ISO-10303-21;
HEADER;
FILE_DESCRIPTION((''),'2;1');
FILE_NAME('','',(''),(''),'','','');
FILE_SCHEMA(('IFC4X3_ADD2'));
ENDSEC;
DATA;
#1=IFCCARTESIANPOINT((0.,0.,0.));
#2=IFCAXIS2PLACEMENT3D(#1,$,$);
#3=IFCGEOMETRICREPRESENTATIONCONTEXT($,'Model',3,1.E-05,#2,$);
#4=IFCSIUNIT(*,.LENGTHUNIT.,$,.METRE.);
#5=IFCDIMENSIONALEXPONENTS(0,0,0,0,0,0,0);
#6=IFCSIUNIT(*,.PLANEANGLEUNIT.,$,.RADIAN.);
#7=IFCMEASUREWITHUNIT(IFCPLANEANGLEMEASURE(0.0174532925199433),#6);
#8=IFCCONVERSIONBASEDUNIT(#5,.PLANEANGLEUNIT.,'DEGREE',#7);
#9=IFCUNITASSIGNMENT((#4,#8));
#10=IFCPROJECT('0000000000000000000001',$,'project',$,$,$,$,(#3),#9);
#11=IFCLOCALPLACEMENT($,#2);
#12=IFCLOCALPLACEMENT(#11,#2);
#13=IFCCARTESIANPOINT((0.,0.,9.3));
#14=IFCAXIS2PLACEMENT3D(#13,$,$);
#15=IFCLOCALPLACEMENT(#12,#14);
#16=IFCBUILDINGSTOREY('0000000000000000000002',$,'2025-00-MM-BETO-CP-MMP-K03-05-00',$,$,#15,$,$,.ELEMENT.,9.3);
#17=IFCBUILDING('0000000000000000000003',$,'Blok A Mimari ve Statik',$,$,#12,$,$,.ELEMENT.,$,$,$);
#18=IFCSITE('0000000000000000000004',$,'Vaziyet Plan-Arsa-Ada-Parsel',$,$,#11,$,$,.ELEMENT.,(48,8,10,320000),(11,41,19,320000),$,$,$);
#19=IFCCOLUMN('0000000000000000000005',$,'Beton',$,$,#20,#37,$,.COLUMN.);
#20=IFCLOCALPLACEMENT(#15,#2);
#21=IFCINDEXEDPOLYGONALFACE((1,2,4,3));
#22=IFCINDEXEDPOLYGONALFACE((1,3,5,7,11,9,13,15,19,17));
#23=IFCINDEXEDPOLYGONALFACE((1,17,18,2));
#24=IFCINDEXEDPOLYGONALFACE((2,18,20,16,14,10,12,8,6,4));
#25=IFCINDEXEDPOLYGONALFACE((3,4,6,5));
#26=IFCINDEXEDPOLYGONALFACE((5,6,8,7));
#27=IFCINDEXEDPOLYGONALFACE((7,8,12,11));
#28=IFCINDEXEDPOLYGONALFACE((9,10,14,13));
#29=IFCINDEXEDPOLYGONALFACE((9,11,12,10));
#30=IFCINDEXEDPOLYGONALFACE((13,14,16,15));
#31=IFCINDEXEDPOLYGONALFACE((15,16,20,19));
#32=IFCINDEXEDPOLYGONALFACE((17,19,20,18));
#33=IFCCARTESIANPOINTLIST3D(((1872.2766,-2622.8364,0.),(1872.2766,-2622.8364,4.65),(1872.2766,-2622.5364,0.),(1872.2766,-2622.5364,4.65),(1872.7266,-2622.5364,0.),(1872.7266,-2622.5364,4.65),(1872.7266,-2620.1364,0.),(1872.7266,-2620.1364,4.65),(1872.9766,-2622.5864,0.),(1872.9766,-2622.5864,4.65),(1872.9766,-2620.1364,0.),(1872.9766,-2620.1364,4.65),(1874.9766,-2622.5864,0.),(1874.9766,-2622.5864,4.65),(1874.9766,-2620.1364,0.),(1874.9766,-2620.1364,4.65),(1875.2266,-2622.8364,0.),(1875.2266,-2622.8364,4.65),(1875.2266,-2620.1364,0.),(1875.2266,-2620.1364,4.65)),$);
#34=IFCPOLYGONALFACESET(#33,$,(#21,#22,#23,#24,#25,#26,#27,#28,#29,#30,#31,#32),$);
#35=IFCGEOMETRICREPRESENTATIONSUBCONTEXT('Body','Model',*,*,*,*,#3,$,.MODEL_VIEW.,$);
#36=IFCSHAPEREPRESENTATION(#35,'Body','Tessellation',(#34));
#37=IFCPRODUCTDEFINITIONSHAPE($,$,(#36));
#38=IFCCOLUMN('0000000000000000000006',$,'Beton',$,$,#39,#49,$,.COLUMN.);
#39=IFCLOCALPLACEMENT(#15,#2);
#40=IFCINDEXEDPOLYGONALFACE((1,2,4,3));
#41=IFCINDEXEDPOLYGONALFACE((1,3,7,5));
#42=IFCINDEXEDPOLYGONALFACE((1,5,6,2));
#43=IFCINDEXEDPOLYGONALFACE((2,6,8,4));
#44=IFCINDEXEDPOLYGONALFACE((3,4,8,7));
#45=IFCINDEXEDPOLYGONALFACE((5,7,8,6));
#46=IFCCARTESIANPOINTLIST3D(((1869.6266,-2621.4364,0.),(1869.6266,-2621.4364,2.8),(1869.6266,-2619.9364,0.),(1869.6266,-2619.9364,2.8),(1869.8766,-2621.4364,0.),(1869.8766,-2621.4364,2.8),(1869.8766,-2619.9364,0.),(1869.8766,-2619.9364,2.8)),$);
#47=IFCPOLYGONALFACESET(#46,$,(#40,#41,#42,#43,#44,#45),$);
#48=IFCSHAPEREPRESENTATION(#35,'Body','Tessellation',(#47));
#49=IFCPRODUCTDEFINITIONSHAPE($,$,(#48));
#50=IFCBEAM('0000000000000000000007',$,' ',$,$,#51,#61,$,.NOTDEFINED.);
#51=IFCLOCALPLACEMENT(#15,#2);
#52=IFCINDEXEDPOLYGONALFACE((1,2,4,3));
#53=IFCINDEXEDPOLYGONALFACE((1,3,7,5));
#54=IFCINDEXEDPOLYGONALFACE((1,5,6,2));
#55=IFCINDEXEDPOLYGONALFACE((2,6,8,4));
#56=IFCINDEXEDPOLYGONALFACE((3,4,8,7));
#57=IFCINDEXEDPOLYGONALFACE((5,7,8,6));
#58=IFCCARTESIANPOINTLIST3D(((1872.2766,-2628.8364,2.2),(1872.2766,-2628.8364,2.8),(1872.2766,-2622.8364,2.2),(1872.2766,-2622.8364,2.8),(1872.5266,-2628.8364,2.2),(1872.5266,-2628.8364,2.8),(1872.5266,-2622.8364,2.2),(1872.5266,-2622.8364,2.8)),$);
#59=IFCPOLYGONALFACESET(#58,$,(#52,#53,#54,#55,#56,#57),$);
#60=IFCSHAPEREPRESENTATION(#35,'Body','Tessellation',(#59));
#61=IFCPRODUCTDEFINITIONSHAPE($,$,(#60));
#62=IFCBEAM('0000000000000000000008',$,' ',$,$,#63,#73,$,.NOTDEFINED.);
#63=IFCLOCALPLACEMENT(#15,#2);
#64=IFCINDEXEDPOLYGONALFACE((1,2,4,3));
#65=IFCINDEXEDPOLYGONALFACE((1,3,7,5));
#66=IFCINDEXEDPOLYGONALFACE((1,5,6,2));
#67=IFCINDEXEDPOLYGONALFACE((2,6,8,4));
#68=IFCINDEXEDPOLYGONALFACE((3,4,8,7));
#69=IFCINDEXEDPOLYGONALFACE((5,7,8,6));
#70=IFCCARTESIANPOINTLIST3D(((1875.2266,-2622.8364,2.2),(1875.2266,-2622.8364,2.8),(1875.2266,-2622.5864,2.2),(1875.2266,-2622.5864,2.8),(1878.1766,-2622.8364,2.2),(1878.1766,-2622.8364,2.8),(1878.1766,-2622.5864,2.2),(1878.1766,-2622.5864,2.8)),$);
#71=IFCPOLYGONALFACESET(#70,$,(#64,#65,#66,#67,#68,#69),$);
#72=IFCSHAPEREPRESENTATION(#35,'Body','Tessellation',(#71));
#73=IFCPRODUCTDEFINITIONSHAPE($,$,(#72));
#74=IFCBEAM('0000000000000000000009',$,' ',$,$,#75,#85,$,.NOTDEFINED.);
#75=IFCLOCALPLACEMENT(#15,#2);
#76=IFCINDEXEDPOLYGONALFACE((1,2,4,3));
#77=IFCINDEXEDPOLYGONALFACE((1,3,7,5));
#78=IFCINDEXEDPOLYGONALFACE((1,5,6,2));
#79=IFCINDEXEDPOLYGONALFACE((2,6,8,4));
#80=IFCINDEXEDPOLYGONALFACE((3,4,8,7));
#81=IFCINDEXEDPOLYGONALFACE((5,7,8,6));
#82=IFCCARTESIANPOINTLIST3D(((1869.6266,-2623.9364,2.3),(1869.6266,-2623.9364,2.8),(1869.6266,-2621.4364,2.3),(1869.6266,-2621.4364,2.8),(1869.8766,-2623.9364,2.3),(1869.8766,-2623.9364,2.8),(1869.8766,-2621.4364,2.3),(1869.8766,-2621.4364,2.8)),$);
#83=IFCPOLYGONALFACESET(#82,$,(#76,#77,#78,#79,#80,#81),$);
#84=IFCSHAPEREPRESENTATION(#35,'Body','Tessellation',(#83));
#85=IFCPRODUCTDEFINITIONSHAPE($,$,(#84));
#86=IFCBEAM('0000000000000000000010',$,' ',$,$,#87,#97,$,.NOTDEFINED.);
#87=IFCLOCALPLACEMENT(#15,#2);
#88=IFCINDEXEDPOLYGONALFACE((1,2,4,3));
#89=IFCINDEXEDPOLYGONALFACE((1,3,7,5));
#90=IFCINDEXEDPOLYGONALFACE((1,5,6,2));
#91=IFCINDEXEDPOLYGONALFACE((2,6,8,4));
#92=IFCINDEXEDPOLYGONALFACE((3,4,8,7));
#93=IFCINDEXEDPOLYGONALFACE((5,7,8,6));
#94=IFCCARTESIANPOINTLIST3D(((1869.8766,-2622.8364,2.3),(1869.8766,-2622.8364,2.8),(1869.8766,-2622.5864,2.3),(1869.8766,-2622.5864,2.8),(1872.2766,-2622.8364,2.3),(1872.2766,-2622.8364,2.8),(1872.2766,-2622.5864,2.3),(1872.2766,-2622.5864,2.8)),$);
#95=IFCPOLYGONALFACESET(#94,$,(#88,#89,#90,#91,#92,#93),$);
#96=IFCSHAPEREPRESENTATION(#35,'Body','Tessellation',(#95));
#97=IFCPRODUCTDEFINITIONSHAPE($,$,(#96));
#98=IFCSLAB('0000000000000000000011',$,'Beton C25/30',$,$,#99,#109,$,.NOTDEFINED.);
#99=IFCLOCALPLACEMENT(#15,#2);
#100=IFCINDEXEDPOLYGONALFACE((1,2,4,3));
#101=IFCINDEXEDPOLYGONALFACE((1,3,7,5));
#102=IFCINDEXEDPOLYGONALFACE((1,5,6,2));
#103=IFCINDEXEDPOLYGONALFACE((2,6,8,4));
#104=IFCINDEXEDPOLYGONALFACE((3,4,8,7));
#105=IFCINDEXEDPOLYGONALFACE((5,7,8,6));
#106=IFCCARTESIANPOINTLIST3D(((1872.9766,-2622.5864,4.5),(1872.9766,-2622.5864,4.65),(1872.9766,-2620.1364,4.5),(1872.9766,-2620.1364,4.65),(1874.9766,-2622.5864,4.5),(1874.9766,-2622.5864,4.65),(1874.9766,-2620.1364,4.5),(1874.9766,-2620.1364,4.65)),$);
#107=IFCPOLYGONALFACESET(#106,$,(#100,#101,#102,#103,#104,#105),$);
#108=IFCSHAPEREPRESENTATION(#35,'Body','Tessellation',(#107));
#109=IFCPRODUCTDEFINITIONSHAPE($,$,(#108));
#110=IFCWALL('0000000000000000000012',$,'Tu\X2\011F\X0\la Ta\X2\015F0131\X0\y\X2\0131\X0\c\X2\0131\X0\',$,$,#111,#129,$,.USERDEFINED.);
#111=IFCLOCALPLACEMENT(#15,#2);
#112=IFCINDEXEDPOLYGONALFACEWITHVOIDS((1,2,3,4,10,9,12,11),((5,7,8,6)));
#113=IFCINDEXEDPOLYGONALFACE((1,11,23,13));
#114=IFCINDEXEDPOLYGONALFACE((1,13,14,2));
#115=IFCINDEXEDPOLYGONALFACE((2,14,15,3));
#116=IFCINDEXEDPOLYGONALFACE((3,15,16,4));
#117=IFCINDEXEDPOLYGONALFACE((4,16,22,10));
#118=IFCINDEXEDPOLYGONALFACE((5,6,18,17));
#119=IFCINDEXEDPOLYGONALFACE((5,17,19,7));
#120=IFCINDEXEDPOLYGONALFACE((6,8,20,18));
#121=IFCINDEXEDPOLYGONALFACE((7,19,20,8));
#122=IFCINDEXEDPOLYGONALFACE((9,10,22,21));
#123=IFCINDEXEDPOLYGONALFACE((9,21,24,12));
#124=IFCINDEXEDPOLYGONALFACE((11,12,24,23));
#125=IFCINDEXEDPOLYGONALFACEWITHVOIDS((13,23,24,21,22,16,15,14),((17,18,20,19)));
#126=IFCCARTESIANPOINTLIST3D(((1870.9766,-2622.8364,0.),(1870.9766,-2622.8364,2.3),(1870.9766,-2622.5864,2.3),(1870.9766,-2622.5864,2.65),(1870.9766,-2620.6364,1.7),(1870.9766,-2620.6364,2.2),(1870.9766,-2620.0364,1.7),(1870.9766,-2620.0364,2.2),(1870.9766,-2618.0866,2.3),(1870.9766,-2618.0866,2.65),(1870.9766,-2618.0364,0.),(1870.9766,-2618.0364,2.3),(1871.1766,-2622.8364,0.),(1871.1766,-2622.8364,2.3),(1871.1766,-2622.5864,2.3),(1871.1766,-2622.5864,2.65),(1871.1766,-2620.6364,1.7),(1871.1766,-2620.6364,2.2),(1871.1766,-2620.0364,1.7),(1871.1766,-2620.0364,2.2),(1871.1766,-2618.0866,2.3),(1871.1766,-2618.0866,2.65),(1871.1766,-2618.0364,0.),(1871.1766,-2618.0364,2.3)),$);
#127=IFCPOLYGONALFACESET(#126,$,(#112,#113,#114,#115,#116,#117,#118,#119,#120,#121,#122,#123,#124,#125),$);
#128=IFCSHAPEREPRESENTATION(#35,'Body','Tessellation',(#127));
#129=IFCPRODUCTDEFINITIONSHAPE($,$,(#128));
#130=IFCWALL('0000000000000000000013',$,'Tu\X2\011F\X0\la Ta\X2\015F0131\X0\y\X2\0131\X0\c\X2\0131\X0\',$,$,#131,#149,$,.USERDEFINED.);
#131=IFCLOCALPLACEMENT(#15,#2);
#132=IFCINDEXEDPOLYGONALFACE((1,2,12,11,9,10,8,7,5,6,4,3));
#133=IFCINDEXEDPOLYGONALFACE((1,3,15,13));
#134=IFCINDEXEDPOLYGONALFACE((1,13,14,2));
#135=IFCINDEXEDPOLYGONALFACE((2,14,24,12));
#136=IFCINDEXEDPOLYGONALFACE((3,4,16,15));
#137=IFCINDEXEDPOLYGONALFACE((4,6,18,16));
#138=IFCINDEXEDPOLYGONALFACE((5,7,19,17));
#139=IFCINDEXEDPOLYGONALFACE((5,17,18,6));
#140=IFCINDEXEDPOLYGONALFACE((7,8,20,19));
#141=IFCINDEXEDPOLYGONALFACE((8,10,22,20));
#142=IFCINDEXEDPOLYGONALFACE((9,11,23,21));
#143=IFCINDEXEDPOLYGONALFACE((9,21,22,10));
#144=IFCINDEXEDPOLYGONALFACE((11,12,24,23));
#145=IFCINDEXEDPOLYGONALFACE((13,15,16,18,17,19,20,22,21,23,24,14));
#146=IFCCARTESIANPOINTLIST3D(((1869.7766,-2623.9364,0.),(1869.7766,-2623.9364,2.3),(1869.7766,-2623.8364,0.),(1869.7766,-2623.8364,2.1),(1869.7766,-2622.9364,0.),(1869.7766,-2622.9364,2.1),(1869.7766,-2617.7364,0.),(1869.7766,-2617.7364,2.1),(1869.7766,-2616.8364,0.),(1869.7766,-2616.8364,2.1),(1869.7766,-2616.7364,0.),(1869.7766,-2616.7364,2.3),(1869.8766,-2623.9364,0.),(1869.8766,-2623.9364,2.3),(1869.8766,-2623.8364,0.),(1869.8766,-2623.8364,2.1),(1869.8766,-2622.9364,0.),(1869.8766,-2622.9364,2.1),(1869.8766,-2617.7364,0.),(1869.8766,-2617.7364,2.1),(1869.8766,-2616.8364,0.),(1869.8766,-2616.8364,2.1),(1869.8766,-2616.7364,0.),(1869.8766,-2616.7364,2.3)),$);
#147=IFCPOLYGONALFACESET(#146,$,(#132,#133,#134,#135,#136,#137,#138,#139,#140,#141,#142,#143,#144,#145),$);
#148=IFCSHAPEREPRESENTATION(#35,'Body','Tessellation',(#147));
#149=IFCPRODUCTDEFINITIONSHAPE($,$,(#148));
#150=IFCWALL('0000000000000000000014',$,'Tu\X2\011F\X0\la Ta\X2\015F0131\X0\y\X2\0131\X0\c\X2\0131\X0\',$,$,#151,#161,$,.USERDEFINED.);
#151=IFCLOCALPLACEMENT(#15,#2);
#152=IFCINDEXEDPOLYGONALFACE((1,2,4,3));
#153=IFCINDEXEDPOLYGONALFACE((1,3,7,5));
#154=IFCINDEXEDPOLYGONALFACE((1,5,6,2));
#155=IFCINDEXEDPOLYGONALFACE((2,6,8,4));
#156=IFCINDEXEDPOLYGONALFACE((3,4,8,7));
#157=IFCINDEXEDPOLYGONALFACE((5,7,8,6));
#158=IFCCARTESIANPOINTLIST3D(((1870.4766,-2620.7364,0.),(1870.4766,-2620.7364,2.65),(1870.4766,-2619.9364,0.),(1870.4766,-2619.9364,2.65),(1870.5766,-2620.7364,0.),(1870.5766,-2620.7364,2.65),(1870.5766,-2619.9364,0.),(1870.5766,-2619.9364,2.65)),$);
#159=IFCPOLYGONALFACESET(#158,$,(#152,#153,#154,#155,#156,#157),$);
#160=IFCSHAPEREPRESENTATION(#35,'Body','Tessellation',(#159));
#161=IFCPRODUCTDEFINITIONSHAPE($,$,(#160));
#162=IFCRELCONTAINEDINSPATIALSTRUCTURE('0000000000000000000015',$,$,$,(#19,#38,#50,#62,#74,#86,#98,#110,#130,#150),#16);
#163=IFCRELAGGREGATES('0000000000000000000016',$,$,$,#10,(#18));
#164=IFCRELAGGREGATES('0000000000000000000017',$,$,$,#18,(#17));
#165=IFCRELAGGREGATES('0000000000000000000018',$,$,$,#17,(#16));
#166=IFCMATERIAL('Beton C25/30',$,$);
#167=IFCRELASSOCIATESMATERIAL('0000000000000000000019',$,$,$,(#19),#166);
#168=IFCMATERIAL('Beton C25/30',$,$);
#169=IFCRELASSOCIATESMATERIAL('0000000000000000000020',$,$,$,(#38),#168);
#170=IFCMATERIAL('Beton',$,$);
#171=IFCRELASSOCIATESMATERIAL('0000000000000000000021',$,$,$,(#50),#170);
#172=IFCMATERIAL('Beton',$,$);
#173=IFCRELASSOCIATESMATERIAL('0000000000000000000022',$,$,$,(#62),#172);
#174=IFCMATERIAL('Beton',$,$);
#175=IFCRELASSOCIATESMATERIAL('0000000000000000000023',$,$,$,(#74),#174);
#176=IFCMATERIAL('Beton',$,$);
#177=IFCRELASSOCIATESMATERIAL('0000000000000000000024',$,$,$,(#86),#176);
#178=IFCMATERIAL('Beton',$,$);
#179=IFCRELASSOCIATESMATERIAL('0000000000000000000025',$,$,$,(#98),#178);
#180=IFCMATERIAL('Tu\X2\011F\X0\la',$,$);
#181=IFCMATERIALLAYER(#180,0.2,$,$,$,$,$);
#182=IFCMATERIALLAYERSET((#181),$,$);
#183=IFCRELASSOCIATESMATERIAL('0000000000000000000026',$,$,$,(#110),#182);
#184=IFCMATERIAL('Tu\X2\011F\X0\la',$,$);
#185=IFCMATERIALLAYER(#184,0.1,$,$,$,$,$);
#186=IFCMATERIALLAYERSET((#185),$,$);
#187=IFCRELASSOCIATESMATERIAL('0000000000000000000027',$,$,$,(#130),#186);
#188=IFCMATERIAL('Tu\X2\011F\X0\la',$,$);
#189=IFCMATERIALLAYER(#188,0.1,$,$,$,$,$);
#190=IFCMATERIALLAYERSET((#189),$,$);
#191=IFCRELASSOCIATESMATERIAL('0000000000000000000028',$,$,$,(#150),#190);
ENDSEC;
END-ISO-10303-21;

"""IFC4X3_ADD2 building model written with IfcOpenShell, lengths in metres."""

from ifc_helpers import new_model, entity, si_unit, converted_unit, frame, frame_2d, origin, origin_with_axes, place, context, subcontext, project, spatial, polyline, rectangle, outline, extrude, clip, bounded_halfspace, material, layer, layer_set, layer_usage, element, save


model = new_model("IFC4X3_ADD2")

# Units and contexts
model_context = context("Model", 3, precision=1e-05, world=origin())
body_context = subcontext(model_context, "Body", "Model", "MODEL_VIEW")
ifc_project = project(units=[si_unit("LENGTHUNIT", "METRE"), converted_unit("PLANEANGLEUNIT", "DEGREE", entity("IfcPlaneAngleMeasure", 0.0174532925199433), si_unit("PLANEANGLEUNIT", "RADIAN"), dimensions=[0, 0, 0, 0, 0, 0, 0])], contexts=[model_context])

# Site, building, storey
site_placement = place(None, origin())
site = spatial("IfcSite", under=ifc_project, at=site_placement, Name="Vaziyet Plan-Arsa-Ada-Parsel", CompositionType="ELEMENT", RefLatitude=(48, 8, 10, 320000), RefLongitude=(11, 41, 19, 320000))
building_placement = place(site_placement, origin())
building = spatial("IfcBuilding", under=site, at=building_placement, Name="Blok A Mimari ve Statik", CompositionType="ELEMENT")
storey_placement = place(building_placement, frame((0.0, 0.0, 9.3)))
storey = spatial("IfcBuildingStorey", under=building, at=storey_placement, Name="2025-00-MM-BETO-CP-MMP-K03-05-00", CompositionType="ELEMENT", Elevation=9.3)

# Columns
ifc_material_1 = material(Name="Beton C25/30")
column_1_placement = place(storey_placement, frame((1872.2766, -2622.8364, 0.0)))
element("IfcColumn", 1, at=column_1_placement, inside=storey, material=ifc_material_1, Name="Beton", PredefinedType="COLUMN", context=body_context, shape_type="SweptSolid", body=[
    extrude(outline(polyline([(0.45, 0.3), (0.0, 0.3), (0.0, 0.0), (2.95, 0.0), (2.95, 2.7), (2.7, 2.7), (2.7, 0.25), (0.7, 0.25), (0.7, 2.7), (0.45, 2.7), (0.45, 0.3)])), origin_with_axes(), (0.0, 0.0, 1.0), 4.65),
])
ifc_material_2 = material(Name="Beton C25/30")
column_2_placement = place(storey_placement, frame((1869.6266, -2621.4364, 0.0)))
element("IfcColumn", 2, at=column_2_placement, inside=storey, material=ifc_material_2, Name="Beton", PredefinedType="COLUMN", context=body_context, shape_type="SweptSolid", body=[
    extrude(outline(polyline([(0.0, 0.0), (0.25, 0.0), (0.25, 1.5), (0.0, 1.5), (0.0, 0.0)])), origin_with_axes(), (0.0, 0.0, 1.0), 2.8),
])

# Beams
ifc_material_3 = material(Name="Beton")
beam_1_placement = place(storey_placement, frame((1872.2766, -2622.8364, 2.2), z_axis=(0.0, 0.0, 1.0), x_axis=(0.0, -1.0, 0.0)))
element("IfcBeam", 3, at=beam_1_placement, inside=storey, material=ifc_material_3, Name=" ", PredefinedType="NOTDEFINED", context=body_context, shape_type="SweptSolid", body=[
    extrude(rectangle(XDim=0.25, YDim=0.6, at=frame_2d((0.125, 0.3), x_axis=(1.0, 0.0))), frame((0.0, 0.0, 0.0), z_axis=(1.0, 0.0, 0.0), x_axis=(0.0, 1.0, 0.0)), (0.0, 0.0, 1.0), 6.0),
])
ifc_material_4 = material(Name="Beton")
beam_2_placement = place(storey_placement, frame((1875.2266, -2622.8364, 2.2)))
element("IfcBeam", 4, at=beam_2_placement, inside=storey, material=ifc_material_4, Name=" ", PredefinedType="NOTDEFINED", context=body_context, shape_type="SweptSolid", body=[
    extrude(rectangle(XDim=0.25, YDim=0.6, at=frame_2d((0.125, 0.3), x_axis=(1.0, 0.0))), frame((0.0, 0.0, 0.0), z_axis=(1.0, 0.0, 0.0), x_axis=(0.0, 1.0, 0.0)), (0.0, 0.0, 1.0), 2.95),
])
ifc_material_5 = material(Name="Beton")
beam_3_placement = place(storey_placement, frame((1869.8766, -2623.9364, 2.3), z_axis=(0.0, 0.0, 1.0), x_axis=(0.0, 1.0, 0.0)))
element("IfcBeam", 5, at=beam_3_placement, inside=storey, material=ifc_material_5, Name=" ", PredefinedType="NOTDEFINED", context=body_context, shape_type="SweptSolid", body=[
    extrude(rectangle(XDim=0.25, YDim=0.5, at=frame_2d((0.125, 0.25), x_axis=(1.0, 0.0))), frame((0.0, 0.0, 0.0), z_axis=(1.0, 0.0, 0.0), x_axis=(0.0, 1.0, 0.0)), (0.0, 0.0, 1.0), 2.5),
])
ifc_material_6 = material(Name="Beton")
beam_4_placement = place(storey_placement, frame((1869.8766, -2622.8364, 2.3), z_axis=(0.0, 0.0, 1.0), x_axis=(1.0, 0.0, 0.0)))
element("IfcBeam", 6, at=beam_4_placement, inside=storey, material=ifc_material_6, Name=" ", PredefinedType="NOTDEFINED", context=body_context, shape_type="SweptSolid", body=[
    extrude(rectangle(XDim=0.25, YDim=0.5, at=frame_2d((0.125, 0.25), x_axis=(1.0, 0.0))), frame((0.0, 0.0, 0.0), z_axis=(1.0, 0.0, 0.0), x_axis=(0.0, 1.0, 0.0)), (0.0, 0.0, 1.0), 2.4),
])

# Slab
ifc_material_7 = material(Name="Beton")
slab_1_placement = place(storey_placement, frame((1872.9766, -2622.5864, 4.5)))
element("IfcSlab", 7, at=slab_1_placement, inside=storey, material=ifc_material_7, Name="Beton C25/30", PredefinedType="NOTDEFINED", context=body_context, shape_type="SweptSolid", body=[
    extrude(rectangle(XDim=2.0, YDim=2.45, at=frame_2d((1.0, 1.225), x_axis=(1.0, 0.0))), origin_with_axes(), (0.0, 0.0, 1.0), 0.15),
])

# Wall, opening
ifc_material_8 = material(Name="Tuğla")
ifc_layer_1 = layer(ifc_material_8, 0.2)
ifc_layer_set_1 = layer_set([ifc_layer_1])
ifc_layer_usage_1 = layer_usage(ifc_layer_set_1, "AXIS2", "POSITIVE", 0.0)
wall_1_placement = place(storey_placement, frame((1871.1766, -2622.8364, 0.0), z_axis=(0.0, 0.0, 1.0), x_axis=(0.0, 1.0, 0.0)))
wall_1 = element("IfcWall", 8, at=wall_1_placement, inside=storey, material=ifc_layer_usage_1, Name="Tuğla Taşıyıcı", PredefinedType="USERDEFINED", context=body_context, shape_type="Clipping", body=[
    clip(clip(extrude(rectangle(XDim=4.8, YDim=0.2, at=frame_2d((2.4, 0.1), x_axis=(1.0, 0.0))), origin_with_axes(), (0.0, 0.0, 1.0), 2.65), bounded_halfspace(frame((0.125, 0.1, 2.3), z_axis=(0.0, 0.0, -1.0), x_axis=(0.0, 1.0, 0.0)), True, origin_with_axes(), polyline([(0.25, 0.0), (0.25, 0.2), (0.0, 0.2), (0.0, 0.0), (0.25, 0.0)]))), bounded_halfspace(frame((4.7749, 0.1, 2.3), z_axis=(0.0, 0.0, -1.0), x_axis=(-1.0, 0.0, 0.0)), True, origin_with_axes(), polyline([(4.8, 0.2), (4.7498, 0.2), (4.7499, 0.0), (4.8, 0.0), (4.8, 0.2)]))),
])
opening_1_placement = place(wall_1_placement, frame((2.2, 0.0, 1.7), z_axis=(0.0, 1.0, 0.0), x_axis=(0.0, 0.0, 1.0)))
element("IfcOpeningElement", 9, at=opening_1_placement, cuts=wall_1, PredefinedType="OPENING", context=body_context, shape_type="SweptSolid", body=[
    extrude(outline(polyline([(0.5, 0.6), (0.5, 0.0), (0.0, 0.0), (0.0, 0.6), (0.5, 0.6)])), origin_with_axes(), (0.0, 0.0, 1.0), 0.2),
])

# Wall, openings
ifc_material_9 = material(Name="Tuğla")
ifc_layer_2 = layer(ifc_material_9, 0.1)
ifc_layer_set_2 = layer_set([ifc_layer_2])
ifc_layer_usage_2 = layer_usage(ifc_layer_set_2, "AXIS2", "POSITIVE", 0.0)
wall_2_placement = place(storey_placement, frame((1869.8766, -2623.9364, 0.0), z_axis=(0.0, 0.0, 1.0), x_axis=(0.0, 1.0, 0.0)))
wall_2 = element("IfcWall", 10, at=wall_2_placement, inside=storey, material=ifc_layer_usage_2, Name="Tuğla Taşıyıcı", PredefinedType="USERDEFINED", context=body_context, shape_type="SweptSolid", body=[
    extrude(rectangle(XDim=7.2, YDim=0.1, at=frame_2d((3.6, 0.05), x_axis=(1.0, 0.0))), origin_with_axes(), (0.0, 0.0, 1.0), 2.3),
])
opening_2_placement = place(wall_2_placement, frame((7.1, 0.1, 0.0), z_axis=(0.0, -1.0, 0.0), x_axis=(0.0, 0.0, 1.0)))
element("IfcOpeningElement", 11, at=opening_2_placement, cuts=wall_2, PredefinedType="OPENING", context=body_context, shape_type="SweptSolid", body=[
    extrude(outline(polyline([(2.1, 0.9), (2.1, 0.0), (0.0, 0.0), (0.0, 0.9), (2.1, 0.9)])), origin_with_axes(), (0.0, 0.0, 1.0), 0.1),
])
opening_3_placement = place(wall_2_placement, frame((1.0, 0.1, 0.0), z_axis=(0.0, -1.0, 0.0), x_axis=(0.0, 0.0, 1.0)))
element("IfcOpeningElement", 12, at=opening_3_placement, cuts=wall_2, PredefinedType="OPENING", context=body_context, shape_type="SweptSolid", body=[
    extrude(outline(polyline([(2.1, 0.9), (2.1, 0.0), (0.0, 0.0), (0.0, 0.9), (2.1, 0.9)])), origin_with_axes(), (0.0, 0.0, 1.0), 0.1),
])

# Wall
ifc_material_10 = material(Name="Tuğla")
ifc_layer_3 = layer(ifc_material_10, 0.1)
ifc_layer_set_3 = layer_set([ifc_layer_3])
ifc_layer_usage_3 = layer_usage(ifc_layer_set_3, "AXIS2", "POSITIVE", 0.0)
wall_3_placement = place(storey_placement, frame((1870.5766, -2620.7364, 0.0), z_axis=(0.0, 0.0, 1.0), x_axis=(0.0, 1.0, 0.0)))
element("IfcWall", 13, at=wall_3_placement, inside=storey, material=ifc_layer_usage_3, Name="Tuğla Taşıyıcı", PredefinedType="USERDEFINED", context=body_context, shape_type="SweptSolid", body=[
    extrude(rectangle(XDim=0.8, YDim=0.1, at=frame_2d((0.4, 0.05), x_axis=(1.0, 0.0))), origin_with_axes(), (0.0, 0.0, 1.0), 2.65),
])

save(model, "model.ifc")
